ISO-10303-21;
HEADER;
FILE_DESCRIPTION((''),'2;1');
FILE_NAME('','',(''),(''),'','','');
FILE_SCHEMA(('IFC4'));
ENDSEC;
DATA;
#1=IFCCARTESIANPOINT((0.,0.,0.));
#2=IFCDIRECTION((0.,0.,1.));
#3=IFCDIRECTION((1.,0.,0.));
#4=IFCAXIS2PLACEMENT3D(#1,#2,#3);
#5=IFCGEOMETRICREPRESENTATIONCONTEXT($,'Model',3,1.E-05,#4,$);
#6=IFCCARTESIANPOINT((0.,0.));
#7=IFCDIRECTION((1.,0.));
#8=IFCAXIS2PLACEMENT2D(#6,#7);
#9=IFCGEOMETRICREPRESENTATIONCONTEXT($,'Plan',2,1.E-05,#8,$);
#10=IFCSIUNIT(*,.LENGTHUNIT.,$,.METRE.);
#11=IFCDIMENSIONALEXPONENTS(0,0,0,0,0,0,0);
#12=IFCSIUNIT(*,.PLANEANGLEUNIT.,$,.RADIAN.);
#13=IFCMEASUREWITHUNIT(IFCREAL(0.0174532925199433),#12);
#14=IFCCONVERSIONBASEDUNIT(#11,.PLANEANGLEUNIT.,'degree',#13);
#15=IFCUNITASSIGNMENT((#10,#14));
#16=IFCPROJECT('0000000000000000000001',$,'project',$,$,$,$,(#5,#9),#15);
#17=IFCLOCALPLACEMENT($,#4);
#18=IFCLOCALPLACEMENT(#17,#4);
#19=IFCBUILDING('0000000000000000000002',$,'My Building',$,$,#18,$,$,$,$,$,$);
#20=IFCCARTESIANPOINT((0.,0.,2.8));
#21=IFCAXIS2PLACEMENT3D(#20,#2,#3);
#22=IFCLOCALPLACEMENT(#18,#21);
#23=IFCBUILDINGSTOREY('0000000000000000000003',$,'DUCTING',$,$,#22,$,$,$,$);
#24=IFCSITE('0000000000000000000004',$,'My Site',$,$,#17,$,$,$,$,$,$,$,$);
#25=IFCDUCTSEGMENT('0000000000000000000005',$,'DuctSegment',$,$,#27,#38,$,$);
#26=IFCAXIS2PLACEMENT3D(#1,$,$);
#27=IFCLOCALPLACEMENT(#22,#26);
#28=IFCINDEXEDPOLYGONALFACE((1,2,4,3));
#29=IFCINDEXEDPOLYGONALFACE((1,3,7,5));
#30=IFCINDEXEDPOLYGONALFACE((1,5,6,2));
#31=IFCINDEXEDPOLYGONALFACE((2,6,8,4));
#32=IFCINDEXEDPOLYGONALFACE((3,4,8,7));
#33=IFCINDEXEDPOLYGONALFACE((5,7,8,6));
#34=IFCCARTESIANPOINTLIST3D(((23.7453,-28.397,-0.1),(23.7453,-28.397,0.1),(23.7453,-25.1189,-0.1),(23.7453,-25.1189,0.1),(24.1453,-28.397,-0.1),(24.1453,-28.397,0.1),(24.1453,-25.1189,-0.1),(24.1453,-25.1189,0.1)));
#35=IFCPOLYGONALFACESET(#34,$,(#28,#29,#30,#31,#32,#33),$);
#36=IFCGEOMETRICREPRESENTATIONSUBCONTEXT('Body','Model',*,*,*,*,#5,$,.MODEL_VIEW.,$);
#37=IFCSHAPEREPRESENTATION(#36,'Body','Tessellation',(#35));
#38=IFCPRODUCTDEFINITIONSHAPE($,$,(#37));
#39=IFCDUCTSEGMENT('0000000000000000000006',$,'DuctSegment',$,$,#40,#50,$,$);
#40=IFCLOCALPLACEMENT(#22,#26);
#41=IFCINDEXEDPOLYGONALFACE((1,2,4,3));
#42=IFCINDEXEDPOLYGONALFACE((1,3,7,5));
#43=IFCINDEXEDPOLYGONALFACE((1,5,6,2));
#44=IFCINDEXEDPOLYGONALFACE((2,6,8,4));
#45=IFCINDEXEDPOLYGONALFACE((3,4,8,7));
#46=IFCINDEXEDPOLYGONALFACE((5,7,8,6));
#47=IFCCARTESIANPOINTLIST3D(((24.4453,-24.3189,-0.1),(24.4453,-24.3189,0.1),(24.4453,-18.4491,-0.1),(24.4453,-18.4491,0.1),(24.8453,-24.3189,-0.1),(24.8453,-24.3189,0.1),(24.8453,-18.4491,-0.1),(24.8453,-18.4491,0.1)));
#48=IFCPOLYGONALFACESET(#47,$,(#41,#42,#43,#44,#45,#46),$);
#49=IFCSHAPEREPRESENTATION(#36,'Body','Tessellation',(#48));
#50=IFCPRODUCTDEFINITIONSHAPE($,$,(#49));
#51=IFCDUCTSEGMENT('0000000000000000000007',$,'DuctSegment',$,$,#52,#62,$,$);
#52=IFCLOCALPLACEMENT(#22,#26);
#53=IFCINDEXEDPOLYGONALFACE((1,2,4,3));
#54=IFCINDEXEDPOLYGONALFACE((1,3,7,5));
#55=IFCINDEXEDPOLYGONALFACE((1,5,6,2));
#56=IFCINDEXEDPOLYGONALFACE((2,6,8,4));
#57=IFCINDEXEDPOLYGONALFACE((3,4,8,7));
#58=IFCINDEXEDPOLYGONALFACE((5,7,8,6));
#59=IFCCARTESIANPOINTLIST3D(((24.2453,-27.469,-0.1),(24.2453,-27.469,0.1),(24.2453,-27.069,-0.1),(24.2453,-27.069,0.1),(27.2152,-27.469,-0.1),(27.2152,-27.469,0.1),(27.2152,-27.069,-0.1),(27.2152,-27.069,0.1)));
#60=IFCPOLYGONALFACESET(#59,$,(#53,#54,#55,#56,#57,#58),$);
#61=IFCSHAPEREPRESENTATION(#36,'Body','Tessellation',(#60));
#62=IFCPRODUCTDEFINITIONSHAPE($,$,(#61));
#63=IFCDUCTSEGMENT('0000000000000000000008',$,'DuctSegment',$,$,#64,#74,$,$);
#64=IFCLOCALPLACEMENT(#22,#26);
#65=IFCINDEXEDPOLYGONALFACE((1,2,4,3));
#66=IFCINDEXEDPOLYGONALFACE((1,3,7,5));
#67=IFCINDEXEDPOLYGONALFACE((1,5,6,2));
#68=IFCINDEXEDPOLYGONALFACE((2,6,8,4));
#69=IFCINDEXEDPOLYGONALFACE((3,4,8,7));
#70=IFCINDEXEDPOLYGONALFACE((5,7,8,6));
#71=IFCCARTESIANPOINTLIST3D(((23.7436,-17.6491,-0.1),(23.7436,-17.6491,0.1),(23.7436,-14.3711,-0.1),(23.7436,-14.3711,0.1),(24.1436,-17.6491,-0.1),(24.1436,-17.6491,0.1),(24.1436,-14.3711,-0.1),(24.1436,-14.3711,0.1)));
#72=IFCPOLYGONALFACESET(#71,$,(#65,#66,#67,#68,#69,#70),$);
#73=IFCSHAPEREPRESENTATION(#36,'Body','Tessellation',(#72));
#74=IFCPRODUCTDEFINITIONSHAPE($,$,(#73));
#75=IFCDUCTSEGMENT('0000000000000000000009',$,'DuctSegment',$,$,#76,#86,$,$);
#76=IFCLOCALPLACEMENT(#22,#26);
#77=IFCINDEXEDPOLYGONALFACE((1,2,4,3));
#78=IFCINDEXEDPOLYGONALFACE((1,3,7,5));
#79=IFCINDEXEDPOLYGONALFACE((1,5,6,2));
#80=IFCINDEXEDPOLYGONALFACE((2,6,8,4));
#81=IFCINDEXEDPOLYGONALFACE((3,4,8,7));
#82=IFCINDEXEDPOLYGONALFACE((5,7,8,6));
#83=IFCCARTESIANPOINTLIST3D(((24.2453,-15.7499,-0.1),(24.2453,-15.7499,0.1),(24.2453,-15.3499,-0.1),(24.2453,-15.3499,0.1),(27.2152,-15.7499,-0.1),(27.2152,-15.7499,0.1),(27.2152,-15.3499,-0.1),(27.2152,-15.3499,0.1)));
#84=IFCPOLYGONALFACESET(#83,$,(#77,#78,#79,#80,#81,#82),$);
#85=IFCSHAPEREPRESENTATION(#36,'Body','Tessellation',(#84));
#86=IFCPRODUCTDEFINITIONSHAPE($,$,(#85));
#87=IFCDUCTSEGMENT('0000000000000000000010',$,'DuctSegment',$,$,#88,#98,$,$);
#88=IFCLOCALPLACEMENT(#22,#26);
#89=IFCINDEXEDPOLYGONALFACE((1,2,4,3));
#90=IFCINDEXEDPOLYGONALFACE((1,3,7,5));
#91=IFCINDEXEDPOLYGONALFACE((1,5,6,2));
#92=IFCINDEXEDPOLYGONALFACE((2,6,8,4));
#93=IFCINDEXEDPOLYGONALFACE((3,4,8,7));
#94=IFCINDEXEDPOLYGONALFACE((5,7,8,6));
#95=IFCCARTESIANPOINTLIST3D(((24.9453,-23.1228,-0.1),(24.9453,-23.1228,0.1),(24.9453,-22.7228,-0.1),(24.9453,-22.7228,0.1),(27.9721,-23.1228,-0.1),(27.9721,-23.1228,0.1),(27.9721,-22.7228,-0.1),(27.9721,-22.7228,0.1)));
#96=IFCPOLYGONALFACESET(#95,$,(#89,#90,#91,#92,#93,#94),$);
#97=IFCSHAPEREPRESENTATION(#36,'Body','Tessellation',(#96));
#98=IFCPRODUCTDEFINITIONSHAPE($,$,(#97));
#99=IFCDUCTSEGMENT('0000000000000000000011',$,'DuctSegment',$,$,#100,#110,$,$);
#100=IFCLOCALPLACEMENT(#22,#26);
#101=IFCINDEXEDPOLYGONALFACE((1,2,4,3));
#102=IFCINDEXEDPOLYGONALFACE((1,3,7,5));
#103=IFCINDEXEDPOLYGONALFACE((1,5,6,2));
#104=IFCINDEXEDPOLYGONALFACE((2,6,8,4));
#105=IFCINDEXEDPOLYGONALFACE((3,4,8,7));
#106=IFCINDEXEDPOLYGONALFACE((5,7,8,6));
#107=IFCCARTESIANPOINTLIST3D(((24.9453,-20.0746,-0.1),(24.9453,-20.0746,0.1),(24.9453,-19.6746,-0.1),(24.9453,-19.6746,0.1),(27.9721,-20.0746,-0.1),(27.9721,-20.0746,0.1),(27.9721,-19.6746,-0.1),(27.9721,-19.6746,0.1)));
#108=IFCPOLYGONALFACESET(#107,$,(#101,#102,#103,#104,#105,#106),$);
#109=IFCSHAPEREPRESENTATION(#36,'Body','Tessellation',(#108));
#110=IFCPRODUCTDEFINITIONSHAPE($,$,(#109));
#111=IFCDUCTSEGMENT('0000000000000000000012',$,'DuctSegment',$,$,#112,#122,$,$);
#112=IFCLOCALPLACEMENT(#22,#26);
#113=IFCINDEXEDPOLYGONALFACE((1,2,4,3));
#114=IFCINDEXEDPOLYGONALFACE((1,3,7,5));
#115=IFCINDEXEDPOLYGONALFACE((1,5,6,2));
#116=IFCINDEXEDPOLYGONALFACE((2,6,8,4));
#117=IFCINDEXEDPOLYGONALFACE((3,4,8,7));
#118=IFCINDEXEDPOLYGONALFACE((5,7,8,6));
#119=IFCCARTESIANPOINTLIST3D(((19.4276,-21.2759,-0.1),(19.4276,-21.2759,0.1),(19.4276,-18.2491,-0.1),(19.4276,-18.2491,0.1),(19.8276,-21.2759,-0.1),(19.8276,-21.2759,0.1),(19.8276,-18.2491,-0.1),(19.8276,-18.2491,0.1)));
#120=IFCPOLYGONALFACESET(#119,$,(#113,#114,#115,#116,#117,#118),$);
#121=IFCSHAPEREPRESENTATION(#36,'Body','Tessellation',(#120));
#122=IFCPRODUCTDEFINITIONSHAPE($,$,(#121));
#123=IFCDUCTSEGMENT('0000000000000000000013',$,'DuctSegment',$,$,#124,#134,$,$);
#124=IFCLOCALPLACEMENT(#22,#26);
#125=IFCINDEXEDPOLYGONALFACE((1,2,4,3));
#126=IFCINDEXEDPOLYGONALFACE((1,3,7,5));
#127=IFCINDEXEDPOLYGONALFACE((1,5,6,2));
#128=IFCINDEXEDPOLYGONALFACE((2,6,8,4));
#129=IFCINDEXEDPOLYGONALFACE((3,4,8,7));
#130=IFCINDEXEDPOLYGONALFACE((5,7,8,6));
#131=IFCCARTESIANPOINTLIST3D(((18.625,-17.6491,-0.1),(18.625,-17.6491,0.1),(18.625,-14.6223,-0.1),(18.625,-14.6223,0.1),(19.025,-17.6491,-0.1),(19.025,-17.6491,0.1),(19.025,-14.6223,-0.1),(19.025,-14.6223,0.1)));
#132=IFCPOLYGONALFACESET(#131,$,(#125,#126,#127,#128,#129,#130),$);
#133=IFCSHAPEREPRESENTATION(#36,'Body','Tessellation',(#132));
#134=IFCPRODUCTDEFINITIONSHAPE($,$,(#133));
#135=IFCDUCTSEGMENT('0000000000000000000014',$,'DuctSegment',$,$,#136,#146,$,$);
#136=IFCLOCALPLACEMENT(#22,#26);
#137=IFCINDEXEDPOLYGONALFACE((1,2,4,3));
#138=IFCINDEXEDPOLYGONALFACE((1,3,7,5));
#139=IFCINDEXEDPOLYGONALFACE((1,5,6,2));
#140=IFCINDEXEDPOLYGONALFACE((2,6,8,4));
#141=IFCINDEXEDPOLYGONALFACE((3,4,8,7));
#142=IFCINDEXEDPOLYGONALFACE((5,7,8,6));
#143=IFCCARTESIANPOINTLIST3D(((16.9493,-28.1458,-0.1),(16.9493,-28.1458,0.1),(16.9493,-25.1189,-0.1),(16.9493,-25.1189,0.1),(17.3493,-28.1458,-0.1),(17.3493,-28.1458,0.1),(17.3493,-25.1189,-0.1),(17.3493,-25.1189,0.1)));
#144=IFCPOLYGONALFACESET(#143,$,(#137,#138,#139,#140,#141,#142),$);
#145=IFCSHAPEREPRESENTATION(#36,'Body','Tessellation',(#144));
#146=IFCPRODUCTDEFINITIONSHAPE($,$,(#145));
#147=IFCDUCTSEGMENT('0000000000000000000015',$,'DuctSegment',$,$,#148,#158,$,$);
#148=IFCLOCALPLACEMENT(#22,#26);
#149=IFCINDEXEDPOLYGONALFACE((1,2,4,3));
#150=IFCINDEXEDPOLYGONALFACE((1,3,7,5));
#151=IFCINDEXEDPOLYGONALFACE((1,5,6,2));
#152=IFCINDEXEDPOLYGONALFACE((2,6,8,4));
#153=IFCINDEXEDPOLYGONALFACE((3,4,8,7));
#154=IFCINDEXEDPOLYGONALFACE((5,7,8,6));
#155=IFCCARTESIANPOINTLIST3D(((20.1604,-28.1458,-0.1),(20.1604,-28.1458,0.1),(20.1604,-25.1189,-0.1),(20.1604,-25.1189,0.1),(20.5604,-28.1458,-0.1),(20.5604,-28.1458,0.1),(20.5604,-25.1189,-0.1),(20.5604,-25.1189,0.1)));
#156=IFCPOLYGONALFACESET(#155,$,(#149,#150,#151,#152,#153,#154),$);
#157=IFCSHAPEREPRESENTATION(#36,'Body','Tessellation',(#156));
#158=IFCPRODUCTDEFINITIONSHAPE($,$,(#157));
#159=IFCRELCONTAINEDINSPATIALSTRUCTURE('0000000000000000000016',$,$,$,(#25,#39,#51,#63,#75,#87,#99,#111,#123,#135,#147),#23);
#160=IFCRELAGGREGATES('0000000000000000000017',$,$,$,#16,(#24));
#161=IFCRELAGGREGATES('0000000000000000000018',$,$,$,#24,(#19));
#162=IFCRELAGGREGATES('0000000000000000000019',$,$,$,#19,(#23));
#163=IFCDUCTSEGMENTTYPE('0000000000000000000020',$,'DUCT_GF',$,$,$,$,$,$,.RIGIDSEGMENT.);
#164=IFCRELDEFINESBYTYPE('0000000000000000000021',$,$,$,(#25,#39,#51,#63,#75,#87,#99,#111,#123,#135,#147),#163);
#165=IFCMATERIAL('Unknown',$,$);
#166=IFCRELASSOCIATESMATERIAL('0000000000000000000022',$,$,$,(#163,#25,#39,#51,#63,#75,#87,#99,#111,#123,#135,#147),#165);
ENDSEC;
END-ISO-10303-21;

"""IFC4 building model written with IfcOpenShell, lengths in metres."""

from ifc_helpers import new_model, entity, si_unit, converted_unit, frame, origin_with_axes, origin_2d_with_axis, place, context, subcontext, project, spatial, rectangle, extrude, material, material_profile, profile_set, profile_usage, type_object, element, save


model = new_model("IFC4")

# Units and contexts
model_context = context("Model", 3, precision=1e-05, world=origin_with_axes())
plan_context = context("Plan", 2, precision=1e-05, world=origin_2d_with_axis())
body_context = subcontext(model_context, "Body", "Model", "MODEL_VIEW")
ifc_project = project(units=[si_unit("LENGTHUNIT", "METRE"), converted_unit("PLANEANGLEUNIT", "degree", entity("IfcReal", 0.0174532925199433), si_unit("PLANEANGLEUNIT", "RADIAN"), dimensions=[0, 0, 0, 0, 0, 0, 0])], contexts=[model_context, plan_context])

# Site, building, storey
site_placement = place(None, origin_with_axes())
site = spatial("IfcSite", under=ifc_project, at=site_placement, Name="My Site")
building_placement = place(site_placement, origin_with_axes())
building = spatial("IfcBuilding", under=site, at=building_placement, Name="My Building")
storey_placement = place(building_placement, frame((0.0, 0.0, 2.8), z_axis=(0.0, 0.0, 1.0), x_axis=(1.0, 0.0, 0.0)))
storey = spatial("IfcBuildingStorey", under=building, at=storey_placement, Name="DUCTING")

# Duct segments
ifc_material = material(Name="Unknown")
ifc_material_profile_1 = material_profile(ifc_material, rectangle(XDim=0.4, YDim=0.2))
ifc_profile_set_1 = profile_set([ifc_material_profile_1])
ifc_profile_usage_1 = profile_usage(ifc_profile_set_1, cardinal=5)
duct_segment_type = type_object("IfcDuctSegmentType", Name="DUCT_GF", PredefinedType="RIGIDSEGMENT", material=ifc_profile_set_1)
duct_segment_1_placement = place(storey_placement, frame((23.9453, -25.1189, 0.0), z_axis=(0.0, -1.0, 0.0), x_axis=(1.0, 0.0, 0.0)))
element("IfcDuctSegment", 1, at=duct_segment_1_placement, inside=storey, type_object=duct_segment_type, material=ifc_profile_usage_1, Name="DuctSegment", context=body_context, shape_type="SweptSolid", body=[
    extrude(rectangle(XDim=0.4, YDim=0.2), origin_with_axes(), (0.0, 0.0, 1.0), 3.278),
])
ifc_profile_usage_2 = profile_usage(ifc_profile_set_1, cardinal=5)
duct_segment_2_placement = place(storey_placement, frame((24.6453, -18.4491, 0.0), z_axis=(0.0, -1.0, 0.0), x_axis=(1.0, 0.0, 0.0)))
element("IfcDuctSegment", 2, at=duct_segment_2_placement, inside=storey, type_object=duct_segment_type, material=ifc_profile_usage_2, Name="DuctSegment", context=body_context, shape_type="SweptSolid", body=[
    extrude(rectangle(XDim=0.4, YDim=0.2), origin_with_axes(), (0.0, 0.0, 1.0), 5.8699),
])
ifc_profile_usage_3 = profile_usage(ifc_profile_set_1, cardinal=5)
duct_segment_3_placement = place(storey_placement, frame((24.2453, -27.269, 0.0), z_axis=(1.0, 0.0, 0.0), x_axis=(0.0, 1.0, 0.0)))
element("IfcDuctSegment", 3, at=duct_segment_3_placement, inside=storey, type_object=duct_segment_type, material=ifc_profile_usage_3, Name="DuctSegment", context=body_context, shape_type="SweptSolid", body=[
    extrude(rectangle(XDim=0.4, YDim=0.2), origin_with_axes(), (0.0, 0.0, 1.0), 2.9699),
])
ifc_profile_usage_4 = profile_usage(ifc_profile_set_1, cardinal=5)
duct_segment_4_placement = place(storey_placement, frame((23.9436, -14.3711, 0.0), z_axis=(0.000001, -1.0, 0.0), x_axis=(1.0, 0.000001, 0.0)))
element("IfcDuctSegment", 4, at=duct_segment_4_placement, inside=storey, type_object=duct_segment_type, material=ifc_profile_usage_4, Name="DuctSegment", context=body_context, shape_type="SweptSolid", body=[
    extrude(rectangle(XDim=0.4, YDim=0.2), origin_with_axes(), (0.0, 0.0, 1.0), 3.278),
])
ifc_profile_usage_5 = profile_usage(ifc_profile_set_1, cardinal=5)
duct_segment_5_placement = place(storey_placement, frame((24.2453, -15.5499, 0.0), z_axis=(1.0, 0.0, 0.0), x_axis=(0.0, 1.0, 0.0)))
element("IfcDuctSegment", 5, at=duct_segment_5_placement, inside=storey, type_object=duct_segment_type, material=ifc_profile_usage_5, Name="DuctSegment", context=body_context, shape_type="SweptSolid", body=[
    extrude(rectangle(XDim=0.4, YDim=0.2), origin_with_axes(), (0.0, 0.0, 1.0), 2.9699),
])
ifc_profile_usage_6 = profile_usage(ifc_profile_set_1, cardinal=5)
duct_segment_6_placement = place(storey_placement, frame((24.9453, -22.9228, 0.0), z_axis=(1.0, 0.0, 0.0), x_axis=(0.0, 1.0, 0.0)))
element("IfcDuctSegment", 6, at=duct_segment_6_placement, inside=storey, type_object=duct_segment_type, material=ifc_profile_usage_6, Name="DuctSegment", context=body_context, shape_type="SweptSolid", body=[
    extrude(rectangle(XDim=0.4, YDim=0.2), origin_with_axes(), (0.0, 0.0, 1.0), 3.0268),
])
ifc_profile_usage_7 = profile_usage(ifc_profile_set_1, cardinal=5)
duct_segment_7_placement = place(storey_placement, frame((24.9453, -19.8746, 0.0), z_axis=(1.0, 0.0, 0.0), x_axis=(0.0, 1.0, 0.0)))
element("IfcDuctSegment", 7, at=duct_segment_7_placement, inside=storey, type_object=duct_segment_type, material=ifc_profile_usage_7, Name="DuctSegment", context=body_context, shape_type="SweptSolid", body=[
    extrude(rectangle(XDim=0.4, YDim=0.2), origin_with_axes(), (0.0, 0.0, 1.0), 3.0268),
])
ifc_profile_usage_8 = profile_usage(ifc_profile_set_1, cardinal=5)
duct_segment_8_placement = place(storey_placement, frame((19.6276, -18.2491, 0.0), z_axis=(0.000001, -1.0, 0.0), x_axis=(1.0, 0.000001, 0.0)))
element("IfcDuctSegment", 8, at=duct_segment_8_placement, inside=storey, type_object=duct_segment_type, material=ifc_profile_usage_8, Name="DuctSegment", context=body_context, shape_type="SweptSolid", body=[
    extrude(rectangle(XDim=0.4, YDim=0.2), origin_with_axes(), (0.0, 0.0, 1.0), 3.0268),
])
ifc_profile_usage_9 = profile_usage(ifc_profile_set_1, cardinal=5)
duct_segment_9_placement = place(storey_placement, frame((18.825, -14.6223, 0.0), z_axis=(0.000001, -1.0, 0.0), x_axis=(1.0, 0.000001, 0.0)))
element("IfcDuctSegment", 9, at=duct_segment_9_placement, inside=storey, type_object=duct_segment_type, material=ifc_profile_usage_9, Name="DuctSegment", context=body_context, shape_type="SweptSolid", body=[
    extrude(rectangle(XDim=0.4, YDim=0.2), origin_with_axes(), (0.0, 0.0, 1.0), 3.0268),
])
ifc_profile_usage_10 = profile_usage(ifc_profile_set_1, cardinal=5)
duct_segment_10_placement = place(storey_placement, frame((17.1493, -25.1189, 0.0), z_axis=(0.000001, -1.0, 0.0), x_axis=(1.0, 0.000001, 0.0)))
element("IfcDuctSegment", 10, at=duct_segment_10_placement, inside=storey, type_object=duct_segment_type, material=ifc_profile_usage_10, Name="DuctSegment", context=body_context, shape_type="SweptSolid", body=[
    extrude(rectangle(XDim=0.4, YDim=0.2), origin_with_axes(), (0.0, 0.0, 1.0), 3.0268),
])
ifc_profile_usage_11 = profile_usage(ifc_profile_set_1, cardinal=5)
duct_segment_11_placement = place(storey_placement, frame((20.3604, -25.1189, 0.0), z_axis=(0.000001, -1.0, 0.0), x_axis=(1.0, 0.000001, 0.0)))
element("IfcDuctSegment", 11, at=duct_segment_11_placement, inside=storey, type_object=duct_segment_type, material=ifc_profile_usage_11, Name="DuctSegment", context=body_context, shape_type="SweptSolid", body=[
    extrude(rectangle(XDim=0.4, YDim=0.2), origin_with_axes(), (0.0, 0.0, 1.0), 3.0268),
])

save(model, "model.ifc")
